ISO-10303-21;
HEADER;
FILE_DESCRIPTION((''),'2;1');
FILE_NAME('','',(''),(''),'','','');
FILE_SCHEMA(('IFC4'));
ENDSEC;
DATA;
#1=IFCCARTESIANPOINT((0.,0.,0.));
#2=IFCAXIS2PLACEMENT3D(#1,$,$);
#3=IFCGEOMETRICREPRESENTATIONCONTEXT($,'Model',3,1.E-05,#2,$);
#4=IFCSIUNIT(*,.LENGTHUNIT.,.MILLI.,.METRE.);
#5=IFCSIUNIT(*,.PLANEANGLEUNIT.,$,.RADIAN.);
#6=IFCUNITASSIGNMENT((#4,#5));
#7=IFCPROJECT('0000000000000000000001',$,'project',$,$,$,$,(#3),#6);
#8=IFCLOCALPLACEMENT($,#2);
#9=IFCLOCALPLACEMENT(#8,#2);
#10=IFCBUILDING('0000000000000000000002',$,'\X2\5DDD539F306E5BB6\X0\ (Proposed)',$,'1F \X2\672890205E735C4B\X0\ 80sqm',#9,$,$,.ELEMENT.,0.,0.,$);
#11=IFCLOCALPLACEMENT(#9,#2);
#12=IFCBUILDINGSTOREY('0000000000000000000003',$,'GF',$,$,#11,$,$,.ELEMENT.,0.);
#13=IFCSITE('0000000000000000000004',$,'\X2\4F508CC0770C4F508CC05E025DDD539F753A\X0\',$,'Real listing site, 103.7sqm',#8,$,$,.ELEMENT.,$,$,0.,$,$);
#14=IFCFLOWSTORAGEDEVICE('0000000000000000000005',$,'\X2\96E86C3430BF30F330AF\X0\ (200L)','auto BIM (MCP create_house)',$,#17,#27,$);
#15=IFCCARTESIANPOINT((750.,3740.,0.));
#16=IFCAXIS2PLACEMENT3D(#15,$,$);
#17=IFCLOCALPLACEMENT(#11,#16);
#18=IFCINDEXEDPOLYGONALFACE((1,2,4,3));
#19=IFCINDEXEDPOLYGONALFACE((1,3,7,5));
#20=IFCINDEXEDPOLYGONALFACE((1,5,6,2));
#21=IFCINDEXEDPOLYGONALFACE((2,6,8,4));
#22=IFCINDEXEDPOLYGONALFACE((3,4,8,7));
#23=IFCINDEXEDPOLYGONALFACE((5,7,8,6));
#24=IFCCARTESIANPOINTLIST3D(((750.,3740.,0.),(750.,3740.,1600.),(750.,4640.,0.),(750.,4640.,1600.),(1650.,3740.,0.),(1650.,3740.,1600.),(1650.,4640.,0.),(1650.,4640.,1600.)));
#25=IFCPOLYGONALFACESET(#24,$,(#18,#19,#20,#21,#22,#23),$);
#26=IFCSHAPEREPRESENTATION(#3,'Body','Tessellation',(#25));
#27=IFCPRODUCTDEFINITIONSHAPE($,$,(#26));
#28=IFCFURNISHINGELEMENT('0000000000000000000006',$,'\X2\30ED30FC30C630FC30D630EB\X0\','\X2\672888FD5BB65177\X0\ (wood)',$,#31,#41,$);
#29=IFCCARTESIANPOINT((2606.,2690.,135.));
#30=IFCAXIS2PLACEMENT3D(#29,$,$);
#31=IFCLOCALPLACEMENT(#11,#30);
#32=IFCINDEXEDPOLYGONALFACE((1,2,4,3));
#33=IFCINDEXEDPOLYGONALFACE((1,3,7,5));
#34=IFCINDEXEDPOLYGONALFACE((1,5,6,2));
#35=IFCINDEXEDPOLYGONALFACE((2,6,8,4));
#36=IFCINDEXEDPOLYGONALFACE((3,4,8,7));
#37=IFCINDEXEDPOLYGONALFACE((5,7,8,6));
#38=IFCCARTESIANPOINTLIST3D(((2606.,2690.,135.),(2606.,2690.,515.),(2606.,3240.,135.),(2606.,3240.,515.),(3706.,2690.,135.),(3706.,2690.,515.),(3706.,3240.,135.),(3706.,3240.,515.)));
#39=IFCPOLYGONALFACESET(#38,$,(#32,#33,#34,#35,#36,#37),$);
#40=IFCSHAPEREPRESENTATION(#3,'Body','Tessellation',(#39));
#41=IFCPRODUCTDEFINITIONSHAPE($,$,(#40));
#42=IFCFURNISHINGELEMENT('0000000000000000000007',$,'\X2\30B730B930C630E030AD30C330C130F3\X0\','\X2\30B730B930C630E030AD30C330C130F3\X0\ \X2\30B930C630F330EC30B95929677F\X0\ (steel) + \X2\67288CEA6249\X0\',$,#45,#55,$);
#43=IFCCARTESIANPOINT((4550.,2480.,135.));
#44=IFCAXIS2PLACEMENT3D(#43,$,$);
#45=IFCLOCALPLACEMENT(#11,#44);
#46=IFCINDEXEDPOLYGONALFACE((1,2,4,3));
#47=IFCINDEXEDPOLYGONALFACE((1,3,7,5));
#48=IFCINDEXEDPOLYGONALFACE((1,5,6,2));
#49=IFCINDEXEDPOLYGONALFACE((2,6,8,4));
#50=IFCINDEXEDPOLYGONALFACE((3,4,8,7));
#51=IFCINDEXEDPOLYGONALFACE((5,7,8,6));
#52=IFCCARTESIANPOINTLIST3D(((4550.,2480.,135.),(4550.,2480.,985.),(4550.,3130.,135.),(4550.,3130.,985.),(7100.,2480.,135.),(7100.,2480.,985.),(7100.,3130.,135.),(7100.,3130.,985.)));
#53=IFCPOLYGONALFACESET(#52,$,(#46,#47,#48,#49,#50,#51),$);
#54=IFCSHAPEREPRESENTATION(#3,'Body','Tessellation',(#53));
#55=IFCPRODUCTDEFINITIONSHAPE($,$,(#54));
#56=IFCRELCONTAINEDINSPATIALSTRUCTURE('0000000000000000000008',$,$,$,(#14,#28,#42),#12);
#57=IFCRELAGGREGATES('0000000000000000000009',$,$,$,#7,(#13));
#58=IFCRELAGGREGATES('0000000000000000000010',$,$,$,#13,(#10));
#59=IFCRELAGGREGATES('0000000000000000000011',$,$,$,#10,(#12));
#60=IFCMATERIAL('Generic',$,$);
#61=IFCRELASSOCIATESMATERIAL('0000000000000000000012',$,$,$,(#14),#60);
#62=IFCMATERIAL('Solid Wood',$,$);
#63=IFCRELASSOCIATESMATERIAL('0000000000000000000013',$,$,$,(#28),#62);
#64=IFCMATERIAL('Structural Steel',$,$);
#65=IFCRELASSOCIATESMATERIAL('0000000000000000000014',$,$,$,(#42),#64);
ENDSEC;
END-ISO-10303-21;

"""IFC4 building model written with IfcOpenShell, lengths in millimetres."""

from ifc_helpers import new_model, si_unit, frame, frame_2d, origin, place, context, project, spatial, rectangle, extrude, material, element, save


model = new_model("IFC4")

# Units and contexts
model_context = context("Model", 3, precision=1e-05, world=origin())
ifc_project = project(units=[si_unit("LENGTHUNIT", "METRE", prefix="MILLI"), si_unit("PLANEANGLEUNIT", "RADIAN")], contexts=[model_context])

# Site, building, storey
site_placement = place(None, origin())
site = spatial("IfcSite", under=ifc_project, at=site_placement, Name="佐賀県佐賀市川原町", ObjectType="Real listing site, 103.7sqm", CompositionType="ELEMENT", RefElevation=0.0)
building_placement = place(site_placement, origin())
building = spatial("IfcBuilding", under=site, at=building_placement, Name="川原の家 (Proposed)", ObjectType="1F 木造平屋 80sqm", CompositionType="ELEMENT", ElevationOfRefHeight=0.0, ElevationOfTerrain=0.0)
storey_placement = place(building_placement, origin())
storey = spatial("IfcBuildingStorey", under=building, at=storey_placement, Name="GF", CompositionType="ELEMENT", Elevation=0.0)

# Shared definitions
ifc_material_1 = material(Name="Solid Wood")

# Shared definitions
ifc_material_2 = material(Name="Generic")

# Flow storage device
flow_storage_device_placement = place(storey_placement, frame((750.0, 3740.0, 0.0)))
element("IfcFlowStorageDevice", 1, at=flow_storage_device_placement, inside=storey, material=ifc_material_2, Name="雨水タンク (200L)", Description="auto BIM (MCP create_house)", context=model_context, shape_type="SweptSolid", body=[
    extrude(rectangle(XDim=900.0, YDim=900.0, at=frame_2d((450.0, 450.0))), frame((750.0, 3740.0, 0.0)), (0.0, 0.0, 1.0), 1600.0),
])

# Furnishing elements
furnishing_1_placement = place(storey_placement, frame((2606.0, 2690.0, 135.0)))
element("IfcFurnishingElement", 2, at=furnishing_1_placement, inside=storey, material=ifc_material_1, Name="ローテーブル", Description="木製家具 (wood)", context=model_context, shape_type="SweptSolid", body=[
    extrude(rectangle(XDim=1100.0, YDim=550.0, at=frame_2d((550.0, 275.0))), frame((2606.0, 2690.0, 135.0)), (0.0, 0.0, 1.0), 380.0),
])
ifc_material_3 = material(Name="Structural Steel")
furnishing_2_placement = place(storey_placement, frame((4550.0, 2480.0, 135.0)))
element("IfcFurnishingElement", 3, at=furnishing_2_placement, inside=storey, material=ifc_material_3, Name="システムキッチン", Description="システムキッチン ステンレス天板 (steel) + 木質扉", context=model_context, shape_type="SweptSolid", body=[
    extrude(rectangle(XDim=2550.0, YDim=650.0, at=frame_2d((1275.0, 325.0))), frame((4550.0, 2480.0, 135.0)), (0.0, 0.0, 1.0), 850.0),
])

save(model, "model.ifc")
